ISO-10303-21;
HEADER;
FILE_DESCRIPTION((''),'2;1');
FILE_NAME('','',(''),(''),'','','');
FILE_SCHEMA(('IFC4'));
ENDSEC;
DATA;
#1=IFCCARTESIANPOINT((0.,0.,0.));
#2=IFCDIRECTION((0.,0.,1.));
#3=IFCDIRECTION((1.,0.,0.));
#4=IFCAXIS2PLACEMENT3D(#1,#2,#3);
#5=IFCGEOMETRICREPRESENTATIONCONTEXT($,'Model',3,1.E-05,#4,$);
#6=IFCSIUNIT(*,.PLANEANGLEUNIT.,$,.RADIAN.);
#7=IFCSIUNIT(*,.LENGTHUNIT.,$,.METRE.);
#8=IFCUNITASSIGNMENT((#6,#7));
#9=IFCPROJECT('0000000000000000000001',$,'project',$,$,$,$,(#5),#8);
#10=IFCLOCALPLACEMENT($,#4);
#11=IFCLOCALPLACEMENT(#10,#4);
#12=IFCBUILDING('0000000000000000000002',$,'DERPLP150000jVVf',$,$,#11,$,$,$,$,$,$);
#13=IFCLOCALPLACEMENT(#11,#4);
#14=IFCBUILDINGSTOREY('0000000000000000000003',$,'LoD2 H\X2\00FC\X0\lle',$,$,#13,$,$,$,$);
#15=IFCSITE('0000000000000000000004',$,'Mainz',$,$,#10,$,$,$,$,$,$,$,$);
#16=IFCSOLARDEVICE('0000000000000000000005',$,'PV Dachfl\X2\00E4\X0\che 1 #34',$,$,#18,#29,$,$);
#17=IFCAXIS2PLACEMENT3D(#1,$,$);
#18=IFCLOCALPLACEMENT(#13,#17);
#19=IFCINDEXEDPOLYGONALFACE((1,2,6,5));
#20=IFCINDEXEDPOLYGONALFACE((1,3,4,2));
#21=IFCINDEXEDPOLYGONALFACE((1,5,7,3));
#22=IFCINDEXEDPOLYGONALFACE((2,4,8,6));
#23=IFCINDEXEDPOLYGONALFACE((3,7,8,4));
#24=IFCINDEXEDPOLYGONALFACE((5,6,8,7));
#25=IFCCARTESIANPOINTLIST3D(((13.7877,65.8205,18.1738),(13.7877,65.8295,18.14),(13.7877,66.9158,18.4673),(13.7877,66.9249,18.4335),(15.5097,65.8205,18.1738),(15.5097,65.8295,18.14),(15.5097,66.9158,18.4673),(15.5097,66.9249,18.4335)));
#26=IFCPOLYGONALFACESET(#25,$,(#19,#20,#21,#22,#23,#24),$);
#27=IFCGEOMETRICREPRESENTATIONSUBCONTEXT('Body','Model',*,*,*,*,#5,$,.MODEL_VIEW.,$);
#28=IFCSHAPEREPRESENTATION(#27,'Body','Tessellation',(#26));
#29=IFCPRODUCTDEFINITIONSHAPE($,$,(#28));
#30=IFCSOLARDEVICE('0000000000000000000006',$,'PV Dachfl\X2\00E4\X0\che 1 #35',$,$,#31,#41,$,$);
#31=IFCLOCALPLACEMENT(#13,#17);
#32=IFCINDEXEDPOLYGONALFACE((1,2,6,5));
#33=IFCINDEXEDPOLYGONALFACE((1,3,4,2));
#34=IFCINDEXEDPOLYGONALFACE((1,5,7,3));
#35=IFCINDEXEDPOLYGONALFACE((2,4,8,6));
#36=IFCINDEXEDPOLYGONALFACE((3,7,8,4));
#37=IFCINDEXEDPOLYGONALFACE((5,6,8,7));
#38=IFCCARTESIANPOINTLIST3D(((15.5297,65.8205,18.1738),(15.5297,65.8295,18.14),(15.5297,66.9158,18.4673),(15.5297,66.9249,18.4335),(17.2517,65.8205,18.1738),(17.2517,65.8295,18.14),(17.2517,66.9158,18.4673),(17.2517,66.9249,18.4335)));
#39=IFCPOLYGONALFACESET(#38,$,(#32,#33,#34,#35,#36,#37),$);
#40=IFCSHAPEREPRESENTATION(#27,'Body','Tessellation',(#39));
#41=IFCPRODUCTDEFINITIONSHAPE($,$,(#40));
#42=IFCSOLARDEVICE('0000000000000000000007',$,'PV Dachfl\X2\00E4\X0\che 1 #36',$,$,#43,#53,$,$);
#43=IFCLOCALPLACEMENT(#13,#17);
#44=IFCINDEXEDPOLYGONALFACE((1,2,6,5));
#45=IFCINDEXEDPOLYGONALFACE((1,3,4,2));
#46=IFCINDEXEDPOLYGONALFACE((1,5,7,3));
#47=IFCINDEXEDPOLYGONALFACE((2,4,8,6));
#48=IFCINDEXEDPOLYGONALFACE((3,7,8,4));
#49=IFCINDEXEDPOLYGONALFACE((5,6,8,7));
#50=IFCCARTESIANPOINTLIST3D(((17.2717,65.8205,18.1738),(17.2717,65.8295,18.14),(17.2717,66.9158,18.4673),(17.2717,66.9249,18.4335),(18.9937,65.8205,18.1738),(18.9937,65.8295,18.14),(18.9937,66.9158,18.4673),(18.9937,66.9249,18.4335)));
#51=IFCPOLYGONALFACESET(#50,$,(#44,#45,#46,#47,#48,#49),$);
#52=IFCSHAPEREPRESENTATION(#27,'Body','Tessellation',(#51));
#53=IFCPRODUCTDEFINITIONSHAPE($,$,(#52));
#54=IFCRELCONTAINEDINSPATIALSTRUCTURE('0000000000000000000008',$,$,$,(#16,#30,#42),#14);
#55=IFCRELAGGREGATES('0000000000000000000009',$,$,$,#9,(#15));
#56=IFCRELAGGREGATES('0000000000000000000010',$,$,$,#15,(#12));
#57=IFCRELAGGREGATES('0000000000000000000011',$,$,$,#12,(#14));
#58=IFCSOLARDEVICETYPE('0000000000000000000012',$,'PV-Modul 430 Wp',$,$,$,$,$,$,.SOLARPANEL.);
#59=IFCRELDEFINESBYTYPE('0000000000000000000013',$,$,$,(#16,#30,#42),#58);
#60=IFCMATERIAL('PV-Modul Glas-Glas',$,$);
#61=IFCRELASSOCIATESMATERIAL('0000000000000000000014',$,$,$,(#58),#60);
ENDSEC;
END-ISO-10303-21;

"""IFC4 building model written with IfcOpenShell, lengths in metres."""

from ifc_helpers import new_model, si_unit, frame, frame_2d, origin, origin_with_axes, place, context, subcontext, project, spatial, rectangle, extrude, source, transform, mapped, material, type_object, type_shapes, element, save


model = new_model("IFC4")

# Units and contexts
model_context = context("Model", 3, precision=1e-05, world=origin_with_axes())
body_context = subcontext(model_context, "Body", "Model", "MODEL_VIEW")
ifc_project = project(units=[si_unit("PLANEANGLEUNIT", "RADIAN"), si_unit("LENGTHUNIT", "METRE")], contexts=[model_context])

# Site, building, storey
site_placement = place(None, origin_with_axes())
site = spatial("IfcSite", under=ifc_project, at=site_placement, Name="Mainz")
building_placement = place(site_placement, origin_with_axes())
building = spatial("IfcBuilding", under=site, at=building_placement, Name="DERPLP150000jVVf")
storey_placement = place(building_placement, origin_with_axes())
storey = spatial("IfcBuildingStorey", under=building, at=storey_placement, Name="LoD2 Hülle")

# Solar devices
ifc_material = material(Name="PV-Modul Glas-Glas")
solar_device_type = type_object("IfcSolarDeviceType", Name="PV-Modul 430 Wp", PredefinedType="SOLARPANEL", material=ifc_material)
shared_shape = source(origin_with_axes(), body_context, "Body", "SweptSolid", [
    extrude(rectangle(XDim=1.722, YDim=1.134, at=frame_2d((0.861, 0.567))), origin(), (0.0, 0.0, 1.0), 0.035),
])
type_shapes(solar_device_type, [shared_shape])
for number, where, z_axis, x_axis, name in (
    (1, (13.7877, 65.8295, 18.14), (0.0, -0.258819, 0.965926), (1.0, 0.0, 0.0), "PV Dachfläche 1 #34"),
    (2, (15.5297, 65.8295, 18.14), (0.0, -0.258819, 0.965926), (1.0, 0.0, 0.0), "PV Dachfläche 1 #35"),
    (3, (17.2717, 65.8295, 18.14), (0.0, -0.258819, 0.965926), (1.0, 0.0, 0.0), "PV Dachfläche 1 #36"),
):
    element("IfcSolarDevice", number, at=place(storey_placement, frame(where, z_axis=z_axis, x_axis=x_axis)), inside=storey, type_object=solar_device_type, Name=name, context=body_context, shape_type="MappedRepresentation", body=[
        mapped(shared_shape, transform((0.0, 0.0, 0.0), x_axis=(1.0, 0.0, 0.0), y_axis=(0.0, 1.0, 0.0), z_axis=(0.0, 0.0, 1.0), scale=1.0)),
    ])

save(model, "model.ifc")
